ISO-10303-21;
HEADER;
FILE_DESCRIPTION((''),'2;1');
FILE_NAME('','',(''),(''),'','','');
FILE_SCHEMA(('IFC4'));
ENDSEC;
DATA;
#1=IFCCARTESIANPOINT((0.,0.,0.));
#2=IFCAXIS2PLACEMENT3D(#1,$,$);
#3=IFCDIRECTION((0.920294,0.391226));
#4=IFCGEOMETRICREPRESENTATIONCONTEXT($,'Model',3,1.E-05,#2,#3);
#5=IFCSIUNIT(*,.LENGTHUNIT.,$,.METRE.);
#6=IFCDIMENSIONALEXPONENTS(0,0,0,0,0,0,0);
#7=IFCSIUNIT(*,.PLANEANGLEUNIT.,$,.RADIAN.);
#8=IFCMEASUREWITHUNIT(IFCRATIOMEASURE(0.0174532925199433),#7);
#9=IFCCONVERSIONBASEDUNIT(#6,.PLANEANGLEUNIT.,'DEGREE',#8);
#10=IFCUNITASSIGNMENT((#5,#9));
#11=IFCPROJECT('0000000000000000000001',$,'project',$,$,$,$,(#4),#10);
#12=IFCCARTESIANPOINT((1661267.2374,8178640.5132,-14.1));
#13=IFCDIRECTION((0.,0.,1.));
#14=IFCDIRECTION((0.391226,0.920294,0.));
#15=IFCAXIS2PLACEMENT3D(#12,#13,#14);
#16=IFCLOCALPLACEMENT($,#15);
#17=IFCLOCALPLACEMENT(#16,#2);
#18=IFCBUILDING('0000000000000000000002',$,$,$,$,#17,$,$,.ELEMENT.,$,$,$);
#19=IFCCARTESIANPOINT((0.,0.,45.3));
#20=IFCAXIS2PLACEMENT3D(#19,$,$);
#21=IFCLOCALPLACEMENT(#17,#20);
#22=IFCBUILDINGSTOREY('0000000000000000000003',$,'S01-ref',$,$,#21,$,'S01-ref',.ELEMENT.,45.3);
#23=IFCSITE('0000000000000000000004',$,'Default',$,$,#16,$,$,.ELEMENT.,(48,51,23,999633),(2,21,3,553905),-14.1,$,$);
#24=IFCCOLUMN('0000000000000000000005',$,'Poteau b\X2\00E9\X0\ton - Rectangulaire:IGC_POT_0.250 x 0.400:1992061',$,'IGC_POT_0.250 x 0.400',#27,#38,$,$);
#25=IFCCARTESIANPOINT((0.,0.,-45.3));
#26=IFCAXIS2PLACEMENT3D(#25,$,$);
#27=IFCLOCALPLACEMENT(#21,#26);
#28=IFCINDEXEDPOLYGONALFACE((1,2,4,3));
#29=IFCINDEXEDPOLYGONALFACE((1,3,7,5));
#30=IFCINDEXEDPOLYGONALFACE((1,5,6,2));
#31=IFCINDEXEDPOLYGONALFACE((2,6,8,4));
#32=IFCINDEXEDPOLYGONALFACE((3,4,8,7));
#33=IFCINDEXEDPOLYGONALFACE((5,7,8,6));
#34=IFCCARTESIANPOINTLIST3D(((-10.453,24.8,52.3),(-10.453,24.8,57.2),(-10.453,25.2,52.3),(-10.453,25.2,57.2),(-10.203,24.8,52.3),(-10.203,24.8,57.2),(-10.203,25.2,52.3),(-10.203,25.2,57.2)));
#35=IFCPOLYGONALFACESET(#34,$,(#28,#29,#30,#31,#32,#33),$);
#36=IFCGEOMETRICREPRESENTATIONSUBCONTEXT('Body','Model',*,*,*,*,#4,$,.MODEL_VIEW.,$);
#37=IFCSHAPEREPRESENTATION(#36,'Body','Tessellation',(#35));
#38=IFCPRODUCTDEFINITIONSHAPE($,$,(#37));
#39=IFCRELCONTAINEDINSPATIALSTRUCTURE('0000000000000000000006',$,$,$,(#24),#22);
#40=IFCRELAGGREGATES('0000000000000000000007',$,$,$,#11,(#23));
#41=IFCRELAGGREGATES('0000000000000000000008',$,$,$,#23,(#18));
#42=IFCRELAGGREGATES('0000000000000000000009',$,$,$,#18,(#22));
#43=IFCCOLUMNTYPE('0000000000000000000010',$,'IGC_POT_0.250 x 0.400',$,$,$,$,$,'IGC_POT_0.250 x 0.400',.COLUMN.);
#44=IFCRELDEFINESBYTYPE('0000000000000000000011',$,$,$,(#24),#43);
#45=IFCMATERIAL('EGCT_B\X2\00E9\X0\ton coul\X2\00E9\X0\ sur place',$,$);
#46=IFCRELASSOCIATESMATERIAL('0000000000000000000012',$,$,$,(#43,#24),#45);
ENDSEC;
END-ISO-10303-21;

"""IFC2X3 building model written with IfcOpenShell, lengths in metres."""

from ifc_helpers import new_model, entity, si_unit, converted_unit, direction, frame, origin, origin_2d_with_axis, place, context, subcontext, project, spatial, rectangle, extrude, source, transform, mapped, material, type_object, type_shapes, element, save


model = new_model("IFC2X3")

# Units and contexts
model_context = context("Model", 3, precision=1e-05, world=origin(), true_north=direction((0.920294, 0.391226)))
body_context = subcontext(model_context, "Body", "Model", "MODEL_VIEW")
ifc_project = project(units=[si_unit("LENGTHUNIT", "METRE"), converted_unit("PLANEANGLEUNIT", "DEGREE", entity("IfcRatioMeasure", 0.0174532925199433), si_unit("PLANEANGLEUNIT", "RADIAN"), dimensions=[0, 0, 0, 0, 0, 0, 0])], contexts=[model_context])

# Site, building, storey
site_placement = place(None, frame((1661267.2374, 8178640.5132, -14.1), z_axis=(0.0, 0.0, 1.0), x_axis=(0.391226, 0.920294, 0.0)))
site = spatial("IfcSite", under=ifc_project, at=site_placement, Name="Default", CompositionType="ELEMENT", RefLatitude=(48, 51, 23, 999633), RefLongitude=(2, 21, 3, 553905), RefElevation=-14.1)
building_placement = place(site_placement, origin())
building = spatial("IfcBuilding", under=site, at=building_placement, CompositionType="ELEMENT")
storey_placement = place(building_placement, frame((0.0, 0.0, 45.3)))
storey = spatial("IfcBuildingStorey", under=building, at=storey_placement, Name="S01-ref", LongName="S01-ref", CompositionType="ELEMENT", Elevation=45.3)

# Column
ifc_material_1 = material(Name="EGCT_Béton coulé sur place")
column_type_1 = type_object("IfcColumnType", Name="IGC_POT_0.250 x 0.400", ElementType="IGC_POT_0.250 x 0.400", PredefinedType="COLUMN", material=ifc_material_1)
shared_shape_1 = source(origin(), body_context, "Body", "SweptSolid", [
    extrude(rectangle(XDim=0.4, YDim=0.25, at=origin_2d_with_axis()), frame((-10.328, 25.0, 52.3), z_axis=(0.0, 0.0, 1.0), x_axis=(0.0, -1.0, 0.0)), (0.0, 0.0, 1.0), 4.9),
])
type_shapes(column_type_1, [shared_shape_1])
column_1_placement = place(storey_placement, frame((0.0, 0.0, -45.3)))
element("IfcColumn", 1, at=column_1_placement, inside=storey, type_object=column_type_1, material=ifc_material_1, Name="Poteau béton - Rectangulaire:IGC_POT_0.250 x 0.400:1992061", ObjectType="IGC_POT_0.250 x 0.400", context=body_context, shape_type="MappedRepresentation", body=[
    mapped(shared_shape_1, transform((0.0, 0.0, 0.0), scale=1.0)),
])

save(model, "model.ifc")
